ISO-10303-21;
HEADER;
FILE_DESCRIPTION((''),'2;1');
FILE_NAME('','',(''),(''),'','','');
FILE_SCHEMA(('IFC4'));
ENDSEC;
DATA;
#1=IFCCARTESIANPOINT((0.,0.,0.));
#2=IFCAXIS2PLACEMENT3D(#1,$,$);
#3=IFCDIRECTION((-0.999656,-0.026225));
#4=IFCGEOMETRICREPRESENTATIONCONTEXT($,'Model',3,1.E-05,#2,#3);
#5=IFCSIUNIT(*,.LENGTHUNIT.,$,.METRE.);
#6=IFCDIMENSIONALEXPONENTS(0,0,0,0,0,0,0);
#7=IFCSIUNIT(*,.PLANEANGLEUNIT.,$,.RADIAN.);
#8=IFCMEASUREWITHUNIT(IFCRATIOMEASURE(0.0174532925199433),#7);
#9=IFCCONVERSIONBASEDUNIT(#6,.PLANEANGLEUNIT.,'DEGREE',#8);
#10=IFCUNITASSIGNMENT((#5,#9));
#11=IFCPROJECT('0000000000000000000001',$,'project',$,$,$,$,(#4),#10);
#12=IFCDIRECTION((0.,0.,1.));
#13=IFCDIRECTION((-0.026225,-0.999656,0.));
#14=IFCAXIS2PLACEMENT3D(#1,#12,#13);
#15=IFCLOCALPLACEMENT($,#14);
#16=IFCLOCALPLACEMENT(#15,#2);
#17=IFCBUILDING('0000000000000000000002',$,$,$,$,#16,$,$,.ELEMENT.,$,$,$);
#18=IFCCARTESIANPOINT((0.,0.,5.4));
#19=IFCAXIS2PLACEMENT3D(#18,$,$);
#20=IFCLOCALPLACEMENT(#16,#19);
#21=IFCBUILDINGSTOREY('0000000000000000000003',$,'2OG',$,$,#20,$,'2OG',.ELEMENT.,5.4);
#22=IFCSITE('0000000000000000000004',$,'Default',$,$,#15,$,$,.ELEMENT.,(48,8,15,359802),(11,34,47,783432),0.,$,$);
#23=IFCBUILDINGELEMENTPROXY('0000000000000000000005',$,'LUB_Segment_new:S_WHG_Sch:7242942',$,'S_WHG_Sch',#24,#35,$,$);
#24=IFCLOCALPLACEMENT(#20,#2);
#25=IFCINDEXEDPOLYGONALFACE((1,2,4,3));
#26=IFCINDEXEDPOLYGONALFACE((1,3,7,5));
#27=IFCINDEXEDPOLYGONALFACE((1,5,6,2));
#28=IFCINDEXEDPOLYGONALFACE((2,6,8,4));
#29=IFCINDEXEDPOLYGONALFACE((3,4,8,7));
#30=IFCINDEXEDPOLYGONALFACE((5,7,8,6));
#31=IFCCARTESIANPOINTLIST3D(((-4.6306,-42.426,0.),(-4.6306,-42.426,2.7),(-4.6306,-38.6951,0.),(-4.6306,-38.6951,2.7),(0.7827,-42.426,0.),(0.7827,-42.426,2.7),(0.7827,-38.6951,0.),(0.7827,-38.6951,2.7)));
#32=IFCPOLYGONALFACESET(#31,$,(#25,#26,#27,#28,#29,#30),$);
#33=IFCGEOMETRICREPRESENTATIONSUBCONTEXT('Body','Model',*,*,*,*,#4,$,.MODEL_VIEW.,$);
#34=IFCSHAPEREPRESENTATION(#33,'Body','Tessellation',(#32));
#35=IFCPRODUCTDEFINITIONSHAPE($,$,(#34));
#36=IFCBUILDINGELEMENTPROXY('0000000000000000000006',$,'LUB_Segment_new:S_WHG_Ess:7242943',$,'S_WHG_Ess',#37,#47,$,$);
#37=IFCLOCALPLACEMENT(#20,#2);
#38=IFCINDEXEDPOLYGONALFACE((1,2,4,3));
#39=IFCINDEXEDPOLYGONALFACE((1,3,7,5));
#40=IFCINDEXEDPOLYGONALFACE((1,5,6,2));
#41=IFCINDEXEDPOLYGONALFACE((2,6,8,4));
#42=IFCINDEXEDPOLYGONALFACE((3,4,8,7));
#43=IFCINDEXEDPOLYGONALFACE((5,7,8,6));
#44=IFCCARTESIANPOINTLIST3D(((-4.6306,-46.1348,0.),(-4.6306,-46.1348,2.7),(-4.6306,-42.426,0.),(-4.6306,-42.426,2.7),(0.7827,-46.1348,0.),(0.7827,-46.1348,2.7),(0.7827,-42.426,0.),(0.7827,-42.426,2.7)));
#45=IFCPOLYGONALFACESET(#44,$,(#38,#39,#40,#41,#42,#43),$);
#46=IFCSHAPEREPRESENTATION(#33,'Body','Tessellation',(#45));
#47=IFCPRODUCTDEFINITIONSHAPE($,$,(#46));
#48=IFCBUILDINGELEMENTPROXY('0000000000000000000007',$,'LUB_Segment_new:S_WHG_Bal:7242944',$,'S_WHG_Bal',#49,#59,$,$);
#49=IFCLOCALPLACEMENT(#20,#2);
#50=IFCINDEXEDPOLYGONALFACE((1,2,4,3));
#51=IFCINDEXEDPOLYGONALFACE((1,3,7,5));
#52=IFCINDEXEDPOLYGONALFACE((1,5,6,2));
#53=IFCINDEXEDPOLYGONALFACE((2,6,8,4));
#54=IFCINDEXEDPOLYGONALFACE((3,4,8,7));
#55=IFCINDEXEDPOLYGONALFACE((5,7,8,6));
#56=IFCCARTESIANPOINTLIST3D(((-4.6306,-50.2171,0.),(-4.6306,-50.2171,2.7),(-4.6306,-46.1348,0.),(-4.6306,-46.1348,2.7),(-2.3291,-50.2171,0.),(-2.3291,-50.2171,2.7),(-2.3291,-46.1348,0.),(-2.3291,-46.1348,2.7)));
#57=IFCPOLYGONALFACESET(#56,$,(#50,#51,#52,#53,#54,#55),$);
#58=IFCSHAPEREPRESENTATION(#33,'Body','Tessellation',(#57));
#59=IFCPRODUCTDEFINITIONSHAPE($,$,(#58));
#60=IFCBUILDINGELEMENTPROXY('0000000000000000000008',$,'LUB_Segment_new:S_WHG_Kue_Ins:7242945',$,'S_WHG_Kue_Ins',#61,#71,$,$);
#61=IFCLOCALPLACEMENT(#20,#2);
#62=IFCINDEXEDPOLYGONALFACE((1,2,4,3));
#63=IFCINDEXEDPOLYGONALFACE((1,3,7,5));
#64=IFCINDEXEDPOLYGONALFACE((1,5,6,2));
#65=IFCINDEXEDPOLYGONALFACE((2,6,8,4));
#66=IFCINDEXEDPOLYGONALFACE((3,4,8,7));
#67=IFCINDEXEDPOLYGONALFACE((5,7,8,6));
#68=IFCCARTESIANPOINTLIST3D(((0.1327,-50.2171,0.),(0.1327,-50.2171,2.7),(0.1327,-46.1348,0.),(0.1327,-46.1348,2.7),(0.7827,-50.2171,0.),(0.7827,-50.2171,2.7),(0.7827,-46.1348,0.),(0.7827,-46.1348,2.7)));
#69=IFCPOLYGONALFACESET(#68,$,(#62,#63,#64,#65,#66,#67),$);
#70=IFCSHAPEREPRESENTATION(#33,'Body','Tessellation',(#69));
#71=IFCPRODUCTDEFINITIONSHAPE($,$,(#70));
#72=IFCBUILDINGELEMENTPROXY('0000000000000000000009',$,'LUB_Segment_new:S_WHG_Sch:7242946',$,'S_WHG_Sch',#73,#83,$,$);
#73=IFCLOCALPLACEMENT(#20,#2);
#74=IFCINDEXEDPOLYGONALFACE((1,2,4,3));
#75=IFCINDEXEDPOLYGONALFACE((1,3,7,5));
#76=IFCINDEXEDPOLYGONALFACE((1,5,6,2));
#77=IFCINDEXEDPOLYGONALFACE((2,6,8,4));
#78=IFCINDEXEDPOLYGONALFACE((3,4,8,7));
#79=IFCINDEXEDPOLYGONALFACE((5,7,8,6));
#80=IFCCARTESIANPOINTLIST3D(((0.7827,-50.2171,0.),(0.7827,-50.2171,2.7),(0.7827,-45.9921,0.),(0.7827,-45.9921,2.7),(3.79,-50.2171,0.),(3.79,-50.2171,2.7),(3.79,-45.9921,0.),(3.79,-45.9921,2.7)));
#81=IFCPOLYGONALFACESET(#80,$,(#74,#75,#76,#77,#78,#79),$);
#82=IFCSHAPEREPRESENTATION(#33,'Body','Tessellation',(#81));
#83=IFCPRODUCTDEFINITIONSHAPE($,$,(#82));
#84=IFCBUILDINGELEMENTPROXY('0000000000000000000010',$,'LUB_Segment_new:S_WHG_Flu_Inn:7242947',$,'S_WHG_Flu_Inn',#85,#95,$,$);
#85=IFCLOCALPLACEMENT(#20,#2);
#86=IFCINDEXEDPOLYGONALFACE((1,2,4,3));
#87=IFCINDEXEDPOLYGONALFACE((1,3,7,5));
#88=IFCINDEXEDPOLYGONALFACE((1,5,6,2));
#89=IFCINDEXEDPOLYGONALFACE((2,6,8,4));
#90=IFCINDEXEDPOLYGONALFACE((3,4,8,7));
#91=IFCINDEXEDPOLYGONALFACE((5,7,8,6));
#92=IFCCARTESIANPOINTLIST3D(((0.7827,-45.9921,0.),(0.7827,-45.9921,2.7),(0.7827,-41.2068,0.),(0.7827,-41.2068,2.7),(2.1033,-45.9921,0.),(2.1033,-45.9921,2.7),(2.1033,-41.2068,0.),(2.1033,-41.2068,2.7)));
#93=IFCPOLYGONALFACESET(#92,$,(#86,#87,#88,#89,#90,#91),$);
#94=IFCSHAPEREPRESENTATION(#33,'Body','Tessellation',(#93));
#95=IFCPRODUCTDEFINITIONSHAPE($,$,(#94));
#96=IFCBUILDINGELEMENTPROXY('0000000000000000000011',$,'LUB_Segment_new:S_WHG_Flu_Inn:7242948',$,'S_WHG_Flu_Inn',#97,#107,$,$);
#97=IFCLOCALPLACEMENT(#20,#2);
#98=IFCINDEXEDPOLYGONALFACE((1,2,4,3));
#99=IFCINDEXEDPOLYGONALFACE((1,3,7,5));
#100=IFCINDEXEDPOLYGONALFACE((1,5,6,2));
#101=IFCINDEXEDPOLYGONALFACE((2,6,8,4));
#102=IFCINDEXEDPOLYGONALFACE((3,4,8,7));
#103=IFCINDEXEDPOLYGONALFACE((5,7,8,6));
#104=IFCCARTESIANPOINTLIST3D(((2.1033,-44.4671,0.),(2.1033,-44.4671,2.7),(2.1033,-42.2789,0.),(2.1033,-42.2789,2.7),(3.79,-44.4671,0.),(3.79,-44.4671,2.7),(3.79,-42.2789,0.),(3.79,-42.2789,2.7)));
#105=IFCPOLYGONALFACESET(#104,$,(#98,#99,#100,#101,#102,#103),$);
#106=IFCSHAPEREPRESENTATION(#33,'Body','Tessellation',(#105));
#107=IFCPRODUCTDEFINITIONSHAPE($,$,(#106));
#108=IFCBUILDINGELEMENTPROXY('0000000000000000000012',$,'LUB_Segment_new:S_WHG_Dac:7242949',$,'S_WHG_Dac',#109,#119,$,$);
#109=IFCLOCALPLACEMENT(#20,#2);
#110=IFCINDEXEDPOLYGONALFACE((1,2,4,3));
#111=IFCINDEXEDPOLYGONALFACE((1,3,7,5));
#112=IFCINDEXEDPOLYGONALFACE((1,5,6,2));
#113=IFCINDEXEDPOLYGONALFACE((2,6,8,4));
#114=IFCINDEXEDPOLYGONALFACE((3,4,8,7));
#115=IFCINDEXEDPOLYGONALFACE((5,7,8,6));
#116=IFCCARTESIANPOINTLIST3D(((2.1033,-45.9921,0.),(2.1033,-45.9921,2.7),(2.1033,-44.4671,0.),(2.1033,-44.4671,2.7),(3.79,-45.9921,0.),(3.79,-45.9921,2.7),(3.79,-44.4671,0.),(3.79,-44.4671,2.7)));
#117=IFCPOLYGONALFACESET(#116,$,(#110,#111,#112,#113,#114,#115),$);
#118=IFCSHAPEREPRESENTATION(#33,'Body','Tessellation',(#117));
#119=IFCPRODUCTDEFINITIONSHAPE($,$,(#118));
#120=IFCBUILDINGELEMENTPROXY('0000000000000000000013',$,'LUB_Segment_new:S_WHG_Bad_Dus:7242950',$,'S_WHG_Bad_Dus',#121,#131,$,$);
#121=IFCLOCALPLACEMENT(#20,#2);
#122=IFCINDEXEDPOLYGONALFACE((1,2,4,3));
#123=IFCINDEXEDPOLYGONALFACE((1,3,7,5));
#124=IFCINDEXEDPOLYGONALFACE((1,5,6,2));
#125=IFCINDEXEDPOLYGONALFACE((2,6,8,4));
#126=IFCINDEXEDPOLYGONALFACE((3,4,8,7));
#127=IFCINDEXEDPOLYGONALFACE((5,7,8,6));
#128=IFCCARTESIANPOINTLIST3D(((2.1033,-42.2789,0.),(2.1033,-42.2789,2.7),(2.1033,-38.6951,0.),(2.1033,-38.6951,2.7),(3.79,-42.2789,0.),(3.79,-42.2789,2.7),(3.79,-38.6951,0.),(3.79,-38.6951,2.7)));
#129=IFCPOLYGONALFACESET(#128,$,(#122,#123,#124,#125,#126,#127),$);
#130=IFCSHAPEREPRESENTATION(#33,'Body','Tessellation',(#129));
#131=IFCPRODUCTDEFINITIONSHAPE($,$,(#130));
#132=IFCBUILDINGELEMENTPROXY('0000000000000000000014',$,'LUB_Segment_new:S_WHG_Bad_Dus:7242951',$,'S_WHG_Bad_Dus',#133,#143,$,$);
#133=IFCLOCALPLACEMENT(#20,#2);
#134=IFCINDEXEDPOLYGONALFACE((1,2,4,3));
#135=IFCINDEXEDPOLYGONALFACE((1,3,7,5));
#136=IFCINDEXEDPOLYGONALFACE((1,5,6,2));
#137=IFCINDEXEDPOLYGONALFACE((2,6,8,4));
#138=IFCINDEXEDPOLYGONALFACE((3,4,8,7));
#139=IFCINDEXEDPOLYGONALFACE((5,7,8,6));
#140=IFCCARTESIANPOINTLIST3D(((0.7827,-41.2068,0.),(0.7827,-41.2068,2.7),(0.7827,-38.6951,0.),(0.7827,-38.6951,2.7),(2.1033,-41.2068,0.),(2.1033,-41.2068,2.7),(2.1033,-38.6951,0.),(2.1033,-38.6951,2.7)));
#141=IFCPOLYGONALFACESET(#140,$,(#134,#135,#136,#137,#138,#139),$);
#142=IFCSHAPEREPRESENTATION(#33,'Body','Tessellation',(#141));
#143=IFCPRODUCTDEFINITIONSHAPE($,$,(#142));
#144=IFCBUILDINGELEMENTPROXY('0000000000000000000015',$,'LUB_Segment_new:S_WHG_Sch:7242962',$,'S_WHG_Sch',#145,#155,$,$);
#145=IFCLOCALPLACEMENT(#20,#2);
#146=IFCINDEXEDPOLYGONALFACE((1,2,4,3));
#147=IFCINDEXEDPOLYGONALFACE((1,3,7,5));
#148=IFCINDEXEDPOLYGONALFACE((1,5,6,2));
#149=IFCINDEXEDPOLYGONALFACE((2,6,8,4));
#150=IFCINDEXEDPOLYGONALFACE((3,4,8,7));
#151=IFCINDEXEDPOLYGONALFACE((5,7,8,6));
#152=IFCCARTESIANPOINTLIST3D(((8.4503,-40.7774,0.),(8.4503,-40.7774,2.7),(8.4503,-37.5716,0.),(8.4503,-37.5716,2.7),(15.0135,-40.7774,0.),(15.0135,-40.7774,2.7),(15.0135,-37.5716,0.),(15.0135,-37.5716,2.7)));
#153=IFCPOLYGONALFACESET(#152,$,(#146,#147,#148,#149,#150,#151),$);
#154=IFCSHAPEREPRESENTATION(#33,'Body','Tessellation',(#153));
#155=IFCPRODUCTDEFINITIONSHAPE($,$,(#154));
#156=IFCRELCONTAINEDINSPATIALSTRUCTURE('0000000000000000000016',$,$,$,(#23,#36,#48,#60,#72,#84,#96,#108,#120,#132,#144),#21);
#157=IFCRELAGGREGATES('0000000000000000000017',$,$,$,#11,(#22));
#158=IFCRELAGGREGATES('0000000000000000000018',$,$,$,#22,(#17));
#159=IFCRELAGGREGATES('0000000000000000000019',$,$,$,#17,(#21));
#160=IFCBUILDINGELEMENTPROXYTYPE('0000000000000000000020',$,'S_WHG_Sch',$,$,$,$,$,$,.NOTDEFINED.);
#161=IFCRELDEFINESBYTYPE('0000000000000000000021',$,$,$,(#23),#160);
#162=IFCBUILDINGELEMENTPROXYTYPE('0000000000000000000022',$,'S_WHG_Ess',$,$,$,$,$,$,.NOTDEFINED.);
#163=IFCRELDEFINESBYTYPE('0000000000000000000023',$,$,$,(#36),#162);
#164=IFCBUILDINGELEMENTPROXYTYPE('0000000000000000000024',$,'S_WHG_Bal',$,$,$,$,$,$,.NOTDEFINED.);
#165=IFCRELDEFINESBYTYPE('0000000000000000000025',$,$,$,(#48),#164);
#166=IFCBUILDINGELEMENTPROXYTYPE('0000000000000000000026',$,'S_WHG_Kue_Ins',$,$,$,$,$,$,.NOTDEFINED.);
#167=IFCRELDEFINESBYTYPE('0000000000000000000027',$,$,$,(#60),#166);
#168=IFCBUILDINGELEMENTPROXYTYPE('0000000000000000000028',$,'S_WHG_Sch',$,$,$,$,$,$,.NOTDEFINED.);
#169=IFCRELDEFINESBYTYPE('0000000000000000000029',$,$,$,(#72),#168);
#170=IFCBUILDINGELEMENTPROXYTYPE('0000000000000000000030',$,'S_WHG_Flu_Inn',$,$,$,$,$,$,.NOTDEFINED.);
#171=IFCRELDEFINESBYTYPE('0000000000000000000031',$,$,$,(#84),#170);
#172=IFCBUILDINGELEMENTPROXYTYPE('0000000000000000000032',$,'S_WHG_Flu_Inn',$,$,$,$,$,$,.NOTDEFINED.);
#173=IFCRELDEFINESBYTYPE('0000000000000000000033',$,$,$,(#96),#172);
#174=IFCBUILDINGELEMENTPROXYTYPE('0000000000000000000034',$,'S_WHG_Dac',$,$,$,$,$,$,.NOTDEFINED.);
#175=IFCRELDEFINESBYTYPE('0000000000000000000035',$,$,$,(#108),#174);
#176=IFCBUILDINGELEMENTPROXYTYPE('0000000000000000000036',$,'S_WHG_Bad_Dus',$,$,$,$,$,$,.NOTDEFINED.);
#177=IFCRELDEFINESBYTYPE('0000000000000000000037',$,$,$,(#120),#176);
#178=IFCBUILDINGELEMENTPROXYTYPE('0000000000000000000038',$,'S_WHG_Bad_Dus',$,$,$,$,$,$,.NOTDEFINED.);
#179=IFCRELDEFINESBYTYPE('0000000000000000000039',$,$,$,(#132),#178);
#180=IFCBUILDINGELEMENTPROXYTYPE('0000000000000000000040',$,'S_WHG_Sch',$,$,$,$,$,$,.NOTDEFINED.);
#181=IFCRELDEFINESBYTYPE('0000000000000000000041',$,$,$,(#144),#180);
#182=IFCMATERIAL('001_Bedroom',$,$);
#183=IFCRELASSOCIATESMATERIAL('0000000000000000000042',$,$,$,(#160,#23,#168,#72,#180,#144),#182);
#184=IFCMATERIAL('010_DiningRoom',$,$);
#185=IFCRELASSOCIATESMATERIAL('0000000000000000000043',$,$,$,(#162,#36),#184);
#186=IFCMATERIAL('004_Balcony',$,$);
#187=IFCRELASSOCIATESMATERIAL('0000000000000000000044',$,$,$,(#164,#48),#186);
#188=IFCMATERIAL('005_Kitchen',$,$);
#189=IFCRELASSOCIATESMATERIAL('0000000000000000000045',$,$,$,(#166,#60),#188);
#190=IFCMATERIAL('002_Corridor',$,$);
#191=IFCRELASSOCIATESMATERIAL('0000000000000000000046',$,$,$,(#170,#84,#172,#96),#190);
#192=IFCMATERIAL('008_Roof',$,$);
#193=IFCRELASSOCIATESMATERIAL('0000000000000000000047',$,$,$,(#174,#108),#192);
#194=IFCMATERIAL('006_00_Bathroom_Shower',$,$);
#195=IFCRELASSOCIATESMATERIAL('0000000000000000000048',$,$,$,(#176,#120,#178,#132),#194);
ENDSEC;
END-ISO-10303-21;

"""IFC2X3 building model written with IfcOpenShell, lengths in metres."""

from ifc_helpers import new_model, entity, si_unit, converted_unit, direction, frame, frame_2d, origin, origin_2d_with_axis, place, context, subcontext, project, spatial, rectangle, extrude, source, transform, mapped, material, type_object, type_shapes, element, save


model = new_model("IFC2X3")

# Units and contexts
model_context = context("Model", 3, precision=1e-05, world=origin(), true_north=direction((-0.999656, -0.026225)))
body_context = subcontext(model_context, "Body", "Model", "MODEL_VIEW")
ifc_project = project(units=[si_unit("LENGTHUNIT", "METRE"), converted_unit("PLANEANGLEUNIT", "DEGREE", entity("IfcRatioMeasure", 0.0174532925199433), si_unit("PLANEANGLEUNIT", "RADIAN"), dimensions=[0, 0, 0, 0, 0, 0, 0])], contexts=[model_context])

# Site, building, storey
site_placement = place(None, frame((0.0, 0.0, 0.0), z_axis=(0.0, 0.0, 1.0), x_axis=(-0.026225, -0.999656, 0.0)))
site = spatial("IfcSite", under=ifc_project, at=site_placement, Name="Default", CompositionType="ELEMENT", RefLatitude=(48, 8, 15, 359802), RefLongitude=(11, 34, 47, 783432), RefElevation=0.0)
building_placement = place(site_placement, origin())
building = spatial("IfcBuilding", under=site, at=building_placement, CompositionType="ELEMENT")
storey_placement = place(building_placement, frame((0.0, 0.0, 5.4)))
storey = spatial("IfcBuildingStorey", under=building, at=storey_placement, Name="2OG", LongName="2OG", CompositionType="ELEMENT", Elevation=5.4)

# Building element proxies
ifc_material_1 = material(Name="001_Bedroom")
building_element_proxy_type_1 = type_object("IfcBuildingElementProxyType", Name="S_WHG_Sch", PredefinedType="NOTDEFINED", material=ifc_material_1)
shared_shape_1 = source(origin(), body_context, "Body", "SweptSolid", [
    extrude(rectangle(XDim=5.4132, YDim=3.7309, at=origin_2d_with_axis()), frame((0.0, 0.0, 0.0), z_axis=(0.0, 0.0, 1.0), x_axis=(-1.0, 0.0, 0.0)), (0.0, 0.0, 1.0), 2.7),
])
type_shapes(building_element_proxy_type_1, [shared_shape_1])
proxy_1_placement = place(storey_placement, frame((-1.924, -40.5605, 0.0)))
element("IfcBuildingElementProxy", 1, at=proxy_1_placement, inside=storey, type_object=building_element_proxy_type_1, material=ifc_material_1, Name="LUB_Segment_new:S_WHG_Sch:7242942", ObjectType="S_WHG_Sch", context=body_context, shape_type="MappedRepresentation", body=[
    mapped(shared_shape_1, transform((0.0, 0.0, 0.0), scale=1.0)),
])
ifc_material_2 = material(Name="010_DiningRoom")
building_element_proxy_type_2 = type_object("IfcBuildingElementProxyType", Name="S_WHG_Ess", PredefinedType="NOTDEFINED", material=ifc_material_2)
shared_shape_2 = source(origin(), body_context, "Body", "SweptSolid", [
    extrude(rectangle(XDim=5.4132, YDim=3.7088, at=origin_2d_with_axis()), frame((0.0, 0.0, 0.0), z_axis=(0.0, 0.0, 1.0), x_axis=(-1.0, 0.0, 0.0)), (0.0, 0.0, 1.0), 2.7),
])
type_shapes(building_element_proxy_type_2, [shared_shape_2])
proxy_2_placement = place(storey_placement, frame((-1.924, -44.2804, 0.0)))
element("IfcBuildingElementProxy", 2, at=proxy_2_placement, inside=storey, type_object=building_element_proxy_type_2, material=ifc_material_2, Name="LUB_Segment_new:S_WHG_Ess:7242943", ObjectType="S_WHG_Ess", context=body_context, shape_type="MappedRepresentation", body=[
    mapped(shared_shape_2, transform((0.0, 0.0, 0.0), scale=1.0)),
])
ifc_material_3 = material(Name="004_Balcony")
building_element_proxy_type_3 = type_object("IfcBuildingElementProxyType", Name="S_WHG_Bal", PredefinedType="NOTDEFINED", material=ifc_material_3)
shared_shape_3 = source(origin(), body_context, "Body", "SweptSolid", [
    extrude(rectangle(XDim=4.0824, YDim=2.3015, at=origin_2d_with_axis()), frame((0.0, 0.0, 0.0), z_axis=(0.0, 0.0, 1.0), x_axis=(0.0, 1.0, 0.0)), (0.0, 0.0, 1.0), 2.7),
])
type_shapes(building_element_proxy_type_3, [shared_shape_3])
proxy_3_placement = place(storey_placement, frame((-3.4798, -48.176, 0.0)))
element("IfcBuildingElementProxy", 3, at=proxy_3_placement, inside=storey, type_object=building_element_proxy_type_3, material=ifc_material_3, Name="LUB_Segment_new:S_WHG_Bal:7242944", ObjectType="S_WHG_Bal", context=body_context, shape_type="MappedRepresentation", body=[
    mapped(shared_shape_3, transform((0.0, 0.0, 0.0), scale=1.0)),
])
ifc_material_4 = material(Name="005_Kitchen")
building_element_proxy_type_4 = type_object("IfcBuildingElementProxyType", Name="S_WHG_Kue_Ins", PredefinedType="NOTDEFINED", material=ifc_material_4)
shared_shape_4 = source(origin(), body_context, "Body", "SweptSolid", [
    extrude(rectangle(XDim=4.0824, YDim=0.65, at=origin_2d_with_axis()), frame((0.0, 0.0, 0.0), z_axis=(0.0, 0.0, 1.0), x_axis=(0.0, 1.0, 0.0)), (0.0, 0.0, 1.0), 2.7),
])
type_shapes(building_element_proxy_type_4, [shared_shape_4])
proxy_4_placement = place(storey_placement, frame((0.4577, -48.176, 0.0)))
element("IfcBuildingElementProxy", 4, at=proxy_4_placement, inside=storey, type_object=building_element_proxy_type_4, material=ifc_material_4, Name="LUB_Segment_new:S_WHG_Kue_Ins:7242945", ObjectType="S_WHG_Kue_Ins", context=body_context, shape_type="MappedRepresentation", body=[
    mapped(shared_shape_4, transform((0.0, 0.0, 0.0), scale=1.0)),
])
building_element_proxy_type_5 = type_object("IfcBuildingElementProxyType", Name="S_WHG_Sch", PredefinedType="NOTDEFINED", material=ifc_material_1)
shared_shape_5 = source(origin(), body_context, "Body", "SweptSolid", [
    extrude(rectangle(XDim=4.225, YDim=3.0074, at=origin_2d_with_axis()), frame((0.0, 0.0, 0.0), z_axis=(0.0, 0.0, 1.0), x_axis=(0.0, 1.0, 0.0)), (0.0, 0.0, 1.0), 2.7),
])
type_shapes(building_element_proxy_type_5, [shared_shape_5])
proxy_5_placement = place(storey_placement, frame((2.2863, -48.1046, 0.0)))
element("IfcBuildingElementProxy", 5, at=proxy_5_placement, inside=storey, type_object=building_element_proxy_type_5, material=ifc_material_1, Name="LUB_Segment_new:S_WHG_Sch:7242946", ObjectType="S_WHG_Sch", context=body_context, shape_type="MappedRepresentation", body=[
    mapped(shared_shape_5, transform((0.0, 0.0, 0.0), scale=1.0)),
])
ifc_material_5 = material(Name="002_Corridor")
building_element_proxy_type_6 = type_object("IfcBuildingElementProxyType", Name="S_WHG_Flu_Inn", PredefinedType="NOTDEFINED", material=ifc_material_5)
shared_shape_6 = source(origin(), body_context, "Body", "SweptSolid", [
    extrude(rectangle(XDim=4.7853, YDim=1.3206, at=origin_2d_with_axis()), frame((0.0, 0.0, 0.0), z_axis=(0.0, 0.0, 1.0), x_axis=(0.0, 1.0, 0.0)), (0.0, 0.0, 1.0), 2.7),
])
type_shapes(building_element_proxy_type_6, [shared_shape_6])
proxy_6_placement = place(storey_placement, frame((1.443, -43.5995, 0.0)))
element("IfcBuildingElementProxy", 6, at=proxy_6_placement, inside=storey, type_object=building_element_proxy_type_6, material=ifc_material_5, Name="LUB_Segment_new:S_WHG_Flu_Inn:7242947", ObjectType="S_WHG_Flu_Inn", context=body_context, shape_type="MappedRepresentation", body=[
    mapped(shared_shape_6, transform((0.0, 0.0, 0.0), scale=1.0)),
])
building_element_proxy_type_7 = type_object("IfcBuildingElementProxyType", Name="S_WHG_Flu_Inn", PredefinedType="NOTDEFINED", material=ifc_material_5)
shared_shape_7 = source(origin(), body_context, "Body", "SweptSolid", [
    extrude(rectangle(XDim=2.1882, YDim=1.6868, at=origin_2d_with_axis()), frame((0.0, 0.0, 0.0), z_axis=(0.0, 0.0, 1.0), x_axis=(0.0, 1.0, 0.0)), (0.0, 0.0, 1.0), 2.7),
])
type_shapes(building_element_proxy_type_7, [shared_shape_7])
proxy_7_placement = place(storey_placement, frame((2.9466, -43.373, 0.0)))
element("IfcBuildingElementProxy", 7, at=proxy_7_placement, inside=storey, type_object=building_element_proxy_type_7, material=ifc_material_5, Name="LUB_Segment_new:S_WHG_Flu_Inn:7242948", ObjectType="S_WHG_Flu_Inn", context=body_context, shape_type="MappedRepresentation", body=[
    mapped(shared_shape_7, transform((0.0, 0.0, 0.0), scale=1.0)),
])
ifc_material_6 = material(Name="008_Roof")
building_element_proxy_type_8 = type_object("IfcBuildingElementProxyType", Name="S_WHG_Dac", PredefinedType="NOTDEFINED", material=ifc_material_6)
shared_shape_8 = source(origin(), body_context, "Body", "SweptSolid", [
    extrude(rectangle(XDim=1.525, YDim=1.6868, at=origin_2d_with_axis()), frame((0.0, 0.0, 0.0), z_axis=(0.0, 0.0, 1.0), x_axis=(0.0, 1.0, 0.0)), (0.0, 0.0, 1.0), 2.7),
])
type_shapes(building_element_proxy_type_8, [shared_shape_8])
proxy_8_placement = place(storey_placement, frame((2.9466, -45.2296, 0.0)))
element("IfcBuildingElementProxy", 8, at=proxy_8_placement, inside=storey, type_object=building_element_proxy_type_8, material=ifc_material_6, Name="LUB_Segment_new:S_WHG_Dac:7242949", ObjectType="S_WHG_Dac", context=body_context, shape_type="MappedRepresentation", body=[
    mapped(shared_shape_8, transform((0.0, 0.0, 0.0), scale=1.0)),
])
ifc_material_7 = material(Name="006_00_Bathroom_Shower")
building_element_proxy_type_9 = type_object("IfcBuildingElementProxyType", Name="S_WHG_Bad_Dus", PredefinedType="NOTDEFINED", material=ifc_material_7)
shared_shape_9 = source(origin(), body_context, "Body", "SweptSolid", [
    extrude(rectangle(XDim=3.5838, YDim=1.6868, at=origin_2d_with_axis()), frame((0.0, 0.0, 0.0), z_axis=(0.0, 0.0, 1.0), x_axis=(0.0, 1.0, 0.0)), (0.0, 0.0, 1.0), 2.7),
])
type_shapes(building_element_proxy_type_9, [shared_shape_9])
proxy_9_placement = place(storey_placement, frame((2.9466, -40.487, 0.0)))
element("IfcBuildingElementProxy", 9, at=proxy_9_placement, inside=storey, type_object=building_element_proxy_type_9, material=ifc_material_7, Name="LUB_Segment_new:S_WHG_Bad_Dus:7242950", ObjectType="S_WHG_Bad_Dus", context=body_context, shape_type="MappedRepresentation", body=[
    mapped(shared_shape_9, transform((0.0, 0.0, 0.0), scale=1.0)),
])
building_element_proxy_type_10 = type_object("IfcBuildingElementProxyType", Name="S_WHG_Bad_Dus", PredefinedType="NOTDEFINED", material=ifc_material_7)
shared_shape_10 = source(origin(), body_context, "Body", "SweptSolid", [
    extrude(rectangle(XDim=2.5118, YDim=1.3206, at=frame_2d((0.0, 0.0), x_axis=(1.0, 0.0))), frame((0.0, 0.0, 0.0), z_axis=(0.0, 0.0, 1.0), x_axis=(0.0, 1.0, 0.0)), (0.0, 0.0, 1.0), 2.7),
])
type_shapes(building_element_proxy_type_10, [shared_shape_10])
proxy_10_placement = place(storey_placement, frame((1.443, -39.951, 0.0)))
element("IfcBuildingElementProxy", 10, at=proxy_10_placement, inside=storey, type_object=building_element_proxy_type_10, material=ifc_material_7, Name="LUB_Segment_new:S_WHG_Bad_Dus:7242951", ObjectType="S_WHG_Bad_Dus", context=body_context, shape_type="MappedRepresentation", body=[
    mapped(shared_shape_10, transform((0.0, 0.0, 0.0), scale=1.0)),
])
building_element_proxy_type_11 = type_object("IfcBuildingElementProxyType", Name="S_WHG_Sch", PredefinedType="NOTDEFINED", material=ifc_material_1)
shared_shape_11 = source(origin(), body_context, "Body", "SweptSolid", [
    extrude(rectangle(XDim=6.5632, YDim=3.2059, at=origin_2d_with_axis()), frame((0.0, 0.0, 0.0), z_axis=(0.0, 0.0, 1.0), x_axis=(-1.0, 0.0, 0.0)), (0.0, 0.0, 1.0), 2.7),
])
type_shapes(building_element_proxy_type_11, [shared_shape_11])
proxy_11_placement = place(storey_placement, frame((11.7319, -39.1745, 0.0)))
element("IfcBuildingElementProxy", 11, at=proxy_11_placement, inside=storey, type_object=building_element_proxy_type_11, material=ifc_material_1, Name="LUB_Segment_new:S_WHG_Sch:7242962", ObjectType="S_WHG_Sch", context=body_context, shape_type="MappedRepresentation", body=[
    mapped(shared_shape_11, transform((0.0, 0.0, 0.0), scale=1.0)),
])

save(model, "model.ifc")
